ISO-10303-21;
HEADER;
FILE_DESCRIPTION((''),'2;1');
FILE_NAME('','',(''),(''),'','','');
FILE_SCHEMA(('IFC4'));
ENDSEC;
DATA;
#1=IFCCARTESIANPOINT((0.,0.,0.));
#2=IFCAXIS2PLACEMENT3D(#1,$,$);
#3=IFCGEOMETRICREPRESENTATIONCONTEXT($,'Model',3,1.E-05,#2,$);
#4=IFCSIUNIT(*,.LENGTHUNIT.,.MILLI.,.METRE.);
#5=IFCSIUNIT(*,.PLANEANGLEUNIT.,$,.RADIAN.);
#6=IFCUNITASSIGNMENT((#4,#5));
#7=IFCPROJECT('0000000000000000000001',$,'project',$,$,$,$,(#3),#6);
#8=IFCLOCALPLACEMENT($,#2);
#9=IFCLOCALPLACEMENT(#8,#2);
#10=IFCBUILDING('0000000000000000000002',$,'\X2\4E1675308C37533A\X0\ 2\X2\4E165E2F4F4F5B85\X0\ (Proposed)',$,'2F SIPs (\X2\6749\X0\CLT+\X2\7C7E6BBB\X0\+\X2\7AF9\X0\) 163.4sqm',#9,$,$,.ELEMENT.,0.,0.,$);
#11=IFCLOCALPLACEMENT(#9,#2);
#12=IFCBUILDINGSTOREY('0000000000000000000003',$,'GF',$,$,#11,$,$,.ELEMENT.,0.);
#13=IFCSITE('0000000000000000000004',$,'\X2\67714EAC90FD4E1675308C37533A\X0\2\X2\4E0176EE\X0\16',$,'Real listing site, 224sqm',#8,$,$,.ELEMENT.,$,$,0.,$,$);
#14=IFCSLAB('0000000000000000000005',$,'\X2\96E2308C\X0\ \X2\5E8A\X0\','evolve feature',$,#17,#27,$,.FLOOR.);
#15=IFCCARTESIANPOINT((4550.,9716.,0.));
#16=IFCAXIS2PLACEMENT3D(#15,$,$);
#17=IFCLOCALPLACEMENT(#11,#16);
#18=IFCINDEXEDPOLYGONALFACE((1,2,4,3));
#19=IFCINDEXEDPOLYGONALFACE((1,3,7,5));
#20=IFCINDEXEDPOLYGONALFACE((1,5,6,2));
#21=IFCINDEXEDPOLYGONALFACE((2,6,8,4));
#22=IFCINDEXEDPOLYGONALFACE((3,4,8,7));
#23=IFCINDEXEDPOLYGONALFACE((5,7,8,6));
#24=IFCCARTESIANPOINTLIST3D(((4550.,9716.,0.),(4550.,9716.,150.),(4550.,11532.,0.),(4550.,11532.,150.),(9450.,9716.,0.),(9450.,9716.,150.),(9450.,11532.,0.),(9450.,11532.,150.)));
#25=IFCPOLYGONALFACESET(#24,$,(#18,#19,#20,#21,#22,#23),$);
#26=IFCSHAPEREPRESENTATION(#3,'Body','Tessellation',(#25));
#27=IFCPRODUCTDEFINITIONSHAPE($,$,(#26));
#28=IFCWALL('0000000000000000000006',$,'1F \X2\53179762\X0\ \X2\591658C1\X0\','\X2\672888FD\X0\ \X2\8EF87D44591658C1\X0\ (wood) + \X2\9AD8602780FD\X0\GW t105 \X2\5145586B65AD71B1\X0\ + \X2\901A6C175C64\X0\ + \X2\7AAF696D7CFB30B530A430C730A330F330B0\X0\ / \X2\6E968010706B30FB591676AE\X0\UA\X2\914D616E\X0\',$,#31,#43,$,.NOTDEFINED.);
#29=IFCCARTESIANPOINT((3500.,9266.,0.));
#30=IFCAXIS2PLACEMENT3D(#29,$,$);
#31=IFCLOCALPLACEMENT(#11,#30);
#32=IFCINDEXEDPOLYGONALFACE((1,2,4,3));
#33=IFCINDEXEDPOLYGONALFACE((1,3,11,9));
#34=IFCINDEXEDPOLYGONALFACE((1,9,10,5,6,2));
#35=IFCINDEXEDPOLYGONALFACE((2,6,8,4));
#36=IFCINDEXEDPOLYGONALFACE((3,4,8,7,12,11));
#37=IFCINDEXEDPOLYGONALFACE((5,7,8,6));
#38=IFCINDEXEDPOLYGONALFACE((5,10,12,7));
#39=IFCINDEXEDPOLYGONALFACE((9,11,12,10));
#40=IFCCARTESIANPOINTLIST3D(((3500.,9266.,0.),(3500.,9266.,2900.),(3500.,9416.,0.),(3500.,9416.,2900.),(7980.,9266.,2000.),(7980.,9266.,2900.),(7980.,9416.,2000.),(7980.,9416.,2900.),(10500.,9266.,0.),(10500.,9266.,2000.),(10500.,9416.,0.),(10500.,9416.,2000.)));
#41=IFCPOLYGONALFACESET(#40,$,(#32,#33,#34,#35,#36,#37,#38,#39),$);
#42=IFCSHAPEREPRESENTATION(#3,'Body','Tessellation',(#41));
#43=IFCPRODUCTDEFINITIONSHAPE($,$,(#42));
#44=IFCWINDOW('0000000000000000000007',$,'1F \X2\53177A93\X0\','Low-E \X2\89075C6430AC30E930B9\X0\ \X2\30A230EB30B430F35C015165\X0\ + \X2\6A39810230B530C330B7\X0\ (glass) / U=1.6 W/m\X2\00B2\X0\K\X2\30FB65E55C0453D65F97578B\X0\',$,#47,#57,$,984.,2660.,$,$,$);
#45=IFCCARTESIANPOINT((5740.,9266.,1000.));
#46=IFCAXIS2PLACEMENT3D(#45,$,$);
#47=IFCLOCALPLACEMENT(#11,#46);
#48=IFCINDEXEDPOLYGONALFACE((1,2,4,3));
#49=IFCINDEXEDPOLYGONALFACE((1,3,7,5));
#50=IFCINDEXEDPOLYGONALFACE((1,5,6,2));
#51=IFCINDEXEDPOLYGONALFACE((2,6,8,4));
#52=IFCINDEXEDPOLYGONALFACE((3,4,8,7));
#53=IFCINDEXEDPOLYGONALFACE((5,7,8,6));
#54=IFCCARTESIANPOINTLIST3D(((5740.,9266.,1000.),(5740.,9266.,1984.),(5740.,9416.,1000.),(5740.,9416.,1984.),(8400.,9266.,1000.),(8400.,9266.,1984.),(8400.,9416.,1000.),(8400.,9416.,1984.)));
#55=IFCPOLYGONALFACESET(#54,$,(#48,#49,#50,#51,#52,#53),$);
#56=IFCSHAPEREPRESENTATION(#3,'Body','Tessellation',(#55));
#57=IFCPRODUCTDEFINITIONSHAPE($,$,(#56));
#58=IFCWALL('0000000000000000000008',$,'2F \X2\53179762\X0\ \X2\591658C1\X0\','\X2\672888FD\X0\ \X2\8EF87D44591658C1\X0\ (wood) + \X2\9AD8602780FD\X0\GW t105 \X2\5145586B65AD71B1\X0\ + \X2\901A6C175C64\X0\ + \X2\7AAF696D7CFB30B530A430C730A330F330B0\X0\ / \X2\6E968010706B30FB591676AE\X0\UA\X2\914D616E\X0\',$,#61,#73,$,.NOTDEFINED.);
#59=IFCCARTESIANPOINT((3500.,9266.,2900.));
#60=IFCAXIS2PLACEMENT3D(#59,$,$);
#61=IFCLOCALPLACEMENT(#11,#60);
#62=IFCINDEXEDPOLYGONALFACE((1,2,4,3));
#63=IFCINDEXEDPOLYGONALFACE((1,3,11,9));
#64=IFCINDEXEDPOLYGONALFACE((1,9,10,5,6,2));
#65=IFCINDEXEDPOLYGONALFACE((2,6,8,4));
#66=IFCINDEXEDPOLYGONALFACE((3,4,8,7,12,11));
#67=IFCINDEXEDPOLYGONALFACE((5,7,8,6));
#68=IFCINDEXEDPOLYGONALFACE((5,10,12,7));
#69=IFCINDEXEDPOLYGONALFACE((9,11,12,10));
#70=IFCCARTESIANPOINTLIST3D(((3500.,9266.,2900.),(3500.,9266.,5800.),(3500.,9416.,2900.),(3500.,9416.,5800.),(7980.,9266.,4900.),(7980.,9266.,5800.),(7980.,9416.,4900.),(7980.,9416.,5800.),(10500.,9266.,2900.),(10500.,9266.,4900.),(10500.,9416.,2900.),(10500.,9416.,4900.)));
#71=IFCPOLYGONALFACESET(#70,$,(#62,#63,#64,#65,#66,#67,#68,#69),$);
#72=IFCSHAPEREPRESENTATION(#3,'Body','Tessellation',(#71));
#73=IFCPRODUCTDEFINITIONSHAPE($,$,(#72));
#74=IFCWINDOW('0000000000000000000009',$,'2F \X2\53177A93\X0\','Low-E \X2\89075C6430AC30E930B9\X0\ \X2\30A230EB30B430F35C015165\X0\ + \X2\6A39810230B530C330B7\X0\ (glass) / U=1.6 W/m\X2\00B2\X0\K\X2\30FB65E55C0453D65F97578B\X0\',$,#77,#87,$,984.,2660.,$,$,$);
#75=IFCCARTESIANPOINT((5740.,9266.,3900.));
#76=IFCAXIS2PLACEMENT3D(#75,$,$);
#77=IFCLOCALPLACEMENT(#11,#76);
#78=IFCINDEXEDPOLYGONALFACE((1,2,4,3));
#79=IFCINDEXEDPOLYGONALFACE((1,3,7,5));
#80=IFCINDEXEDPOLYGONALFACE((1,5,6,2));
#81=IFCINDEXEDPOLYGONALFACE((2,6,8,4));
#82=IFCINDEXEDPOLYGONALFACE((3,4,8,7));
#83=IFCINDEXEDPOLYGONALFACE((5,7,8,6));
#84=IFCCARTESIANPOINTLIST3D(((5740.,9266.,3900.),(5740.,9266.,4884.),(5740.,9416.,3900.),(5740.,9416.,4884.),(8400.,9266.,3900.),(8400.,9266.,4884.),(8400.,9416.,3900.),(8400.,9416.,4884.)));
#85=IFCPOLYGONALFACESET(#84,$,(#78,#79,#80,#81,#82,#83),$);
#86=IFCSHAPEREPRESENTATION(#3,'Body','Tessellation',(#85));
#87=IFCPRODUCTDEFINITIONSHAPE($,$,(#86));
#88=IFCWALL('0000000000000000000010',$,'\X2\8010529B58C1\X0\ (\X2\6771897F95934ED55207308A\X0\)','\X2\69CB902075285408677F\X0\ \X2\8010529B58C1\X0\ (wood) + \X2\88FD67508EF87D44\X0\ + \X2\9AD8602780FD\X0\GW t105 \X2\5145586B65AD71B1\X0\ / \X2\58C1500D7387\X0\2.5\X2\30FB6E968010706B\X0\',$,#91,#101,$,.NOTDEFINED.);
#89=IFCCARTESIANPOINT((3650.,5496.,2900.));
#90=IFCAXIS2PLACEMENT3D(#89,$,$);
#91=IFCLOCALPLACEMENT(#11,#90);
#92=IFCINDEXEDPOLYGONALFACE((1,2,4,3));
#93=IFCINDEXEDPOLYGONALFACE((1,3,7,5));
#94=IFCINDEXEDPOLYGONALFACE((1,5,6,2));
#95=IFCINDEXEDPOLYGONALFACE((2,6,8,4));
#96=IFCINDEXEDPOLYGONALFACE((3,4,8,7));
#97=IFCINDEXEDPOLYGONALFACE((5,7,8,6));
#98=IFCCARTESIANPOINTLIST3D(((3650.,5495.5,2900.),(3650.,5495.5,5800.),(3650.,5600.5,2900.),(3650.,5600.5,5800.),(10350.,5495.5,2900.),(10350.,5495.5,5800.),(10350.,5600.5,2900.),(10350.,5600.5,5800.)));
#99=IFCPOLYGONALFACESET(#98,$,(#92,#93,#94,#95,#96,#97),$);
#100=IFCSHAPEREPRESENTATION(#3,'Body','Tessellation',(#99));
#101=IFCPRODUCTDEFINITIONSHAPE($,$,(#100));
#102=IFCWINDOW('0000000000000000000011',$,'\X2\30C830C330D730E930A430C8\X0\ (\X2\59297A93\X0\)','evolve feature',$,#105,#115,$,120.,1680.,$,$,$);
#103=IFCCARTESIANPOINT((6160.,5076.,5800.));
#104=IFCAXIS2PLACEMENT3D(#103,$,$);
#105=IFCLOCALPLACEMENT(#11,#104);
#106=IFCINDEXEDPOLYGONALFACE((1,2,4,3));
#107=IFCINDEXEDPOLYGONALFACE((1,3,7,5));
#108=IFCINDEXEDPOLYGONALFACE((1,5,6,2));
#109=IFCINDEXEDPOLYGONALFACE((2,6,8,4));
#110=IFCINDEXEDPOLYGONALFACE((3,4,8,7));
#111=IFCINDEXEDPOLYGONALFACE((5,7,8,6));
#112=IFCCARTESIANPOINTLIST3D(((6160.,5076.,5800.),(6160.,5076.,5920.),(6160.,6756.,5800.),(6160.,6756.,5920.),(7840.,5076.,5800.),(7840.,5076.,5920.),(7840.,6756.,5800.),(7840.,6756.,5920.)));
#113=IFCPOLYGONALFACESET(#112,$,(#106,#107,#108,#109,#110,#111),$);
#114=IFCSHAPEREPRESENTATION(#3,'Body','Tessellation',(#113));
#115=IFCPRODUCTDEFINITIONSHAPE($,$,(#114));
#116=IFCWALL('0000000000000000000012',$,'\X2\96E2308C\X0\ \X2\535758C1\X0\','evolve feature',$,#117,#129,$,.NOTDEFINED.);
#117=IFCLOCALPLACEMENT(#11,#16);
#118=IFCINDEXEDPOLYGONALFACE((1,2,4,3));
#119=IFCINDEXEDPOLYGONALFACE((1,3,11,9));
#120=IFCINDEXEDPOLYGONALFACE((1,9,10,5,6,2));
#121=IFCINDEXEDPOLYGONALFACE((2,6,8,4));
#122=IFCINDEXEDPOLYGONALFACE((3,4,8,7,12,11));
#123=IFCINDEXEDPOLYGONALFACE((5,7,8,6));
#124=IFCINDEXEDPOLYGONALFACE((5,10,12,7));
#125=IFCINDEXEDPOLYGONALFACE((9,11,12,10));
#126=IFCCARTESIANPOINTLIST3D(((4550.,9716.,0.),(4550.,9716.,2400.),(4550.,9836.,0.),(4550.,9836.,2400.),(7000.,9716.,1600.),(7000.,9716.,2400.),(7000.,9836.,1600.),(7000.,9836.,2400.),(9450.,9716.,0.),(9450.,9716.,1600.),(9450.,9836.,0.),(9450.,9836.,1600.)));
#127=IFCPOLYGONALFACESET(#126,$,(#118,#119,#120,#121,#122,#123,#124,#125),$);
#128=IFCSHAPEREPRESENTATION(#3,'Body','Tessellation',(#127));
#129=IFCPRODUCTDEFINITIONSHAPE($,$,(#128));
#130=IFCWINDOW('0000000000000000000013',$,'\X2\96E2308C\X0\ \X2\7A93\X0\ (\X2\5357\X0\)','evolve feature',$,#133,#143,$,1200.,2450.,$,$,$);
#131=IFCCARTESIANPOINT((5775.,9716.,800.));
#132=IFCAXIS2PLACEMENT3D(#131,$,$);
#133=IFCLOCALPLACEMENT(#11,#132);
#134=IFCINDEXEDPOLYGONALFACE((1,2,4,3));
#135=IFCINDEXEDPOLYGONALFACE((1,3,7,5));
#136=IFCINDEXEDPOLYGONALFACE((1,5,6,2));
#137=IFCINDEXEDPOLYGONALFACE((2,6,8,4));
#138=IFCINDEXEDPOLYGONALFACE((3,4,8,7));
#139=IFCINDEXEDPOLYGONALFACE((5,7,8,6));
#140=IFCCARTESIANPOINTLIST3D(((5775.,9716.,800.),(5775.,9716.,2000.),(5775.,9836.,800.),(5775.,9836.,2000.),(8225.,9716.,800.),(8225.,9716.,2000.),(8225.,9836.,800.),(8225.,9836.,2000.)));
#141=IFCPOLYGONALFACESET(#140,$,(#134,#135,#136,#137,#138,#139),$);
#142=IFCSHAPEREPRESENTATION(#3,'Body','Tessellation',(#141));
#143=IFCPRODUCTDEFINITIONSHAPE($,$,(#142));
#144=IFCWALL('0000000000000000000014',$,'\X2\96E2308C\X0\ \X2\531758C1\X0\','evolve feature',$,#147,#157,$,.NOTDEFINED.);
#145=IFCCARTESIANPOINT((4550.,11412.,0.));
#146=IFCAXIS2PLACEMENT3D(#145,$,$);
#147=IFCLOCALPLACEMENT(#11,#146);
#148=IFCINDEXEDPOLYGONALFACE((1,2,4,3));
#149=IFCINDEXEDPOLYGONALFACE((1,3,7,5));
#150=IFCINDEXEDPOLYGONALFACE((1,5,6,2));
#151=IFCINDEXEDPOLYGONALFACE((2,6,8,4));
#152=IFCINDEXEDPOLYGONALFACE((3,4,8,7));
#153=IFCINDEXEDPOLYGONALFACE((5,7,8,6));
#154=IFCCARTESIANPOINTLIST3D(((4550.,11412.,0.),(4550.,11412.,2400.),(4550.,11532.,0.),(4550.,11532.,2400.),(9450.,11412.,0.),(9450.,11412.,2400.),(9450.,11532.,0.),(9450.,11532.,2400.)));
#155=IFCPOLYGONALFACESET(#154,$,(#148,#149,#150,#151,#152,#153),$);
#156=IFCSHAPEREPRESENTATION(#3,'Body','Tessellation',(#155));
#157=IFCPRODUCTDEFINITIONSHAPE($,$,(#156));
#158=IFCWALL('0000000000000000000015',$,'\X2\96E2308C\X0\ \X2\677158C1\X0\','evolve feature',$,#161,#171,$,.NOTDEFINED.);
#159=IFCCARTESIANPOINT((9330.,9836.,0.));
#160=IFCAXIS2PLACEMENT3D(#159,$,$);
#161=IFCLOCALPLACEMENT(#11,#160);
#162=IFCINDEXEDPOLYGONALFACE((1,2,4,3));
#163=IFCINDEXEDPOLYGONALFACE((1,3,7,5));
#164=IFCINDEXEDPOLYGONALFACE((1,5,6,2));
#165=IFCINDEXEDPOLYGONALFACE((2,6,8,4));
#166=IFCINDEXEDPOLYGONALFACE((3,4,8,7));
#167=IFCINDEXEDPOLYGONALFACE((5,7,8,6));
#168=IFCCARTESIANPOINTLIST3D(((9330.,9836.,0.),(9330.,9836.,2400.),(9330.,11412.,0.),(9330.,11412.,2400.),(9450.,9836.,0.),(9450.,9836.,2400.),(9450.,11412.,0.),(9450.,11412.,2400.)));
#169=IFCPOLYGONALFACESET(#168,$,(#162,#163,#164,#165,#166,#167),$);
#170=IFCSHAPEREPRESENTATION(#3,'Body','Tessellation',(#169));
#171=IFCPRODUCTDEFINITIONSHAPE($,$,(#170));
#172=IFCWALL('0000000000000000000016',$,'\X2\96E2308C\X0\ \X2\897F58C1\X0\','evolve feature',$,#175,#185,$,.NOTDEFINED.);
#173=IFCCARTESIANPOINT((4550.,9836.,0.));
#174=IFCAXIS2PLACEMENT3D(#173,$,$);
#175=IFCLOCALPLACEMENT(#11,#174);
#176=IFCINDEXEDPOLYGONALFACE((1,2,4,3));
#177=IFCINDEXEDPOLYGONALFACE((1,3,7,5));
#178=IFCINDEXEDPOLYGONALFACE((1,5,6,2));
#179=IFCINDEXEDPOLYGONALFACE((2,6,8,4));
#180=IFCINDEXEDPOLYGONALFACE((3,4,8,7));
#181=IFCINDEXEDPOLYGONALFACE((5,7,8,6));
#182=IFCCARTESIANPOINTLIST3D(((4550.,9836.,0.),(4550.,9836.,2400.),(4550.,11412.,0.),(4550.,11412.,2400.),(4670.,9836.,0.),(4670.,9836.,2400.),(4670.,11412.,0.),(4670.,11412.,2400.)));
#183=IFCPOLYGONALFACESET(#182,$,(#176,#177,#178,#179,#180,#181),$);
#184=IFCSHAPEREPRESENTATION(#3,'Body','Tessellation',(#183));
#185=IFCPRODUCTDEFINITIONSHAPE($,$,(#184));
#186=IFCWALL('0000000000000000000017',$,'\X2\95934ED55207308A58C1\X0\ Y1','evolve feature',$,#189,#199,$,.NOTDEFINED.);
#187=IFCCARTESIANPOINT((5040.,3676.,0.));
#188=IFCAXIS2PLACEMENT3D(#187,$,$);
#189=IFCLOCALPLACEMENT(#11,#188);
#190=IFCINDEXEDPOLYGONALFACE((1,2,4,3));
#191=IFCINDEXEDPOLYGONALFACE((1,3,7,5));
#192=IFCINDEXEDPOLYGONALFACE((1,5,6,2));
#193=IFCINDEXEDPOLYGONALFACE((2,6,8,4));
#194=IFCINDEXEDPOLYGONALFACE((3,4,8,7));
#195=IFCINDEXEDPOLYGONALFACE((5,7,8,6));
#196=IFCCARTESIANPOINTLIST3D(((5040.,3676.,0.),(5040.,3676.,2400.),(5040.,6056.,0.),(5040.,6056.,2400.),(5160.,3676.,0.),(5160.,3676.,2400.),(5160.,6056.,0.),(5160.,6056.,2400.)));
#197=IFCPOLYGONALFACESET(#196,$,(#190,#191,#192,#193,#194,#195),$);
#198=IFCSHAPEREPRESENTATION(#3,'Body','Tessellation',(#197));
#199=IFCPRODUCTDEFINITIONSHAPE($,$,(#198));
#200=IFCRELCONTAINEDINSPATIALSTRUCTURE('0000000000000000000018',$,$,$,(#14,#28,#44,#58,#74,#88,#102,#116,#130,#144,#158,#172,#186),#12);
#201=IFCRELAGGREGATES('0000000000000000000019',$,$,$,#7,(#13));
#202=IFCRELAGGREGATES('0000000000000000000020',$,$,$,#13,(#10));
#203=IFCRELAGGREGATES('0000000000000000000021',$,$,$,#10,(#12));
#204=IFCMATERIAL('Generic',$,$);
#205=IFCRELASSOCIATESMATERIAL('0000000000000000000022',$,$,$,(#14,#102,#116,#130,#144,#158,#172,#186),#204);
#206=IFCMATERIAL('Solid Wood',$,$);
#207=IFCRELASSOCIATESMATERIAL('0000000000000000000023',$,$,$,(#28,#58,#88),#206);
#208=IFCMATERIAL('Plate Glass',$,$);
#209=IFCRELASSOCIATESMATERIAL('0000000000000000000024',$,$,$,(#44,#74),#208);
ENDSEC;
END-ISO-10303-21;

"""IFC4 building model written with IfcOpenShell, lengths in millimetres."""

from ifc_helpers import new_model, si_unit, frame, frame_2d, origin, place, context, project, spatial, rectangle, extrude, material, element, fill, save


model = new_model("IFC4")

# Units and contexts
model_context = context("Model", 3, precision=1e-05, world=origin())
ifc_project = project(units=[si_unit("LENGTHUNIT", "METRE", prefix="MILLI"), si_unit("PLANEANGLEUNIT", "RADIAN")], contexts=[model_context])

# Site, building, storey
site_placement = place(None, origin())
site = spatial("IfcSite", under=ifc_project, at=site_placement, Name="東京都世田谷区2丁目16", ObjectType="Real listing site, 224sqm", CompositionType="ELEMENT", RefElevation=0.0)
building_placement = place(site_placement, origin())
building = spatial("IfcBuilding", under=site, at=building_placement, Name="世田谷区 2世帯住宅 (Proposed)", ObjectType="2F SIPs (杉CLT+籾殻+竹) 163.4sqm", CompositionType="ELEMENT", ElevationOfRefHeight=0.0, ElevationOfTerrain=0.0)
storey_placement = place(building_placement, origin())
storey = spatial("IfcBuildingStorey", under=building, at=storey_placement, Name="GF", CompositionType="ELEMENT", Elevation=0.0)

# Slab
ifc_material_1 = material(Name="Generic")
slab_placement = place(storey_placement, frame((4550.0, 9716.0, 0.0)))
element("IfcSlab", 1, at=slab_placement, inside=storey, material=ifc_material_1, Name="離れ 床", Description="evolve feature", PredefinedType="FLOOR", context=model_context, shape_type="SweptSolid", body=[
    extrude(rectangle(XDim=4900.0, YDim=1816.0, at=frame_2d((2450.0, 908.0))), frame((4550.0, 9716.0, 0.0)), (0.0, 0.0, 1.0), 150.0),
])

# Wall, opening, window
ifc_material_2 = material(Name="Solid Wood")
wall_1_placement = place(storey_placement, frame((3500.0, 9266.0, 0.0)))
wall_1 = element("IfcWall", 2, at=wall_1_placement, inside=storey, material=ifc_material_2, Name="1F 北面 外壁", Description="木製 軸組外壁 (wood) + 高性能GW t105 充填断熱 + 通気層 + 窯業系サイディング / 準耐火・外皮UA配慮", PredefinedType="NOTDEFINED", context=model_context, shape_type="SweptSolid", body=[
    extrude(rectangle(XDim=7000.0, YDim=150.0, at=frame_2d((3500.0, 75.0))), frame((3500.0, 9266.0, 0.0)), (0.0, 0.0, 1.0), 2900.0),
])
opening_1_placement = place(storey_placement, frame((5740.0, 9266.0, 1000.0)))
opening_1 = element("IfcOpeningElement", 3, at=opening_1_placement, cuts=wall_1, PredefinedType="NOTDEFINED", context=model_context, shape_type="SweptSolid", body=[
    extrude(rectangle(XDim=2660.0, YDim=150.0, at=frame_2d((1330.0, 75.0))), frame((5740.0, 9266.0, 1000.0)), (0.0, 0.0, 1.0), 984.0),
])
ifc_material_3 = material(Name="Plate Glass")
window_1_placement = place(storey_placement, frame((5740.0, 9266.0, 1000.0)))
window_1 = element("IfcWindow", 4, at=window_1_placement, inside=storey, material=ifc_material_3, Name="1F 北窓", Description="Low-E 複層ガラス アルゴン封入 + 樹脂サッシ (glass) / U=1.6 W/m²K・日射取得型", OverallHeight=984.0, OverallWidth=2660.0, context=model_context, shape_type="SweptSolid", body=[
    extrude(rectangle(XDim=2660.0, YDim=150.0, at=frame_2d((1330.0, 75.0))), frame((5740.0, 9266.0, 1000.0)), (0.0, 0.0, 1.0), 984.0),
])
fill(opening_1, window_1)

# Wall, opening, window
wall_2_placement = place(storey_placement, frame((3500.0, 9266.0, 2900.0)))
wall_2 = element("IfcWall", 5, at=wall_2_placement, inside=storey, material=ifc_material_2, Name="2F 北面 外壁", Description="木製 軸組外壁 (wood) + 高性能GW t105 充填断熱 + 通気層 + 窯業系サイディング / 準耐火・外皮UA配慮", PredefinedType="NOTDEFINED", context=model_context, shape_type="SweptSolid", body=[
    extrude(rectangle(XDim=7000.0, YDim=150.0, at=frame_2d((3500.0, 75.0))), frame((3500.0, 9266.0, 2900.0)), (0.0, 0.0, 1.0), 2900.0),
])
opening_2_placement = place(storey_placement, frame((5740.0, 9266.0, 3900.0)))
opening_2 = element("IfcOpeningElement", 6, at=opening_2_placement, cuts=wall_2, PredefinedType="NOTDEFINED", context=model_context, shape_type="SweptSolid", body=[
    extrude(rectangle(XDim=2660.0, YDim=150.0, at=frame_2d((1330.0, 75.0))), frame((5740.0, 9266.0, 3900.0)), (0.0, 0.0, 1.0), 984.0),
])
window_2_placement = place(storey_placement, frame((5740.0, 9266.0, 3900.0)))
window_2 = element("IfcWindow", 7, at=window_2_placement, inside=storey, material=ifc_material_3, Name="2F 北窓", Description="Low-E 複層ガラス アルゴン封入 + 樹脂サッシ (glass) / U=1.6 W/m²K・日射取得型", OverallHeight=984.0, OverallWidth=2660.0, context=model_context, shape_type="SweptSolid", body=[
    extrude(rectangle(XDim=2660.0, YDim=150.0, at=frame_2d((1330.0, 75.0))), frame((5740.0, 9266.0, 3900.0)), (0.0, 0.0, 1.0), 984.0),
])
fill(opening_2, window_2)

# Wall
wall_3_placement = place(storey_placement, frame((3650.0, 5496.0, 2900.0)))
element("IfcWall", 8, at=wall_3_placement, inside=storey, material=ifc_material_2, Name="耐力壁 (東西間仕切り)", Description="構造用合板 耐力壁 (wood) + 製材軸組 + 高性能GW t105 充填断熱 / 壁倍率2.5・準耐火", PredefinedType="NOTDEFINED", context=model_context, shape_type="SweptSolid", body=[
    extrude(rectangle(XDim=6700.0, YDim=105.0, at=frame_2d((3350.0, 52.0))), frame((3650.0, 5496.0, 2900.0)), (0.0, 0.0, 1.0), 2900.0),
])

# Window
window_3_placement = place(storey_placement, frame((6160.0, 5076.0, 5800.0)))
element("IfcWindow", 9, at=window_3_placement, inside=storey, material=ifc_material_1, Name="トップライト (天窓)", Description="evolve feature", OverallHeight=120.0, OverallWidth=1680.0, context=model_context, shape_type="SweptSolid", body=[
    extrude(rectangle(XDim=1680.0, YDim=1680.0, at=frame_2d((840.0, 840.0))), frame((6160.0, 5076.0, 5800.0)), (0.0, 0.0, 1.0), 120.0),
])

# Wall, opening, window
wall_4_placement = place(storey_placement, frame((4550.0, 9716.0, 0.0)))
wall_4 = element("IfcWall", 10, at=wall_4_placement, inside=storey, material=ifc_material_1, Name="離れ 南壁", Description="evolve feature", PredefinedType="NOTDEFINED", context=model_context, shape_type="SweptSolid", body=[
    extrude(rectangle(XDim=4900.0, YDim=120.0, at=frame_2d((2450.0, 60.0))), frame((4550.0, 9716.0, 0.0)), (0.0, 0.0, 1.0), 2400.0),
])
opening_3_placement = place(storey_placement, frame((5775.0, 9716.0, 800.0)))
opening_3 = element("IfcOpeningElement", 11, at=opening_3_placement, cuts=wall_4, PredefinedType="NOTDEFINED", context=model_context, shape_type="SweptSolid", body=[
    extrude(rectangle(XDim=2450.0, YDim=120.0, at=frame_2d((1225.0, 60.0))), frame((5775.0, 9716.0, 800.0)), (0.0, 0.0, 1.0), 1200.0),
])
window_4_placement = place(storey_placement, frame((5775.0, 9716.0, 800.0)))
window_4 = element("IfcWindow", 12, at=window_4_placement, inside=storey, material=ifc_material_1, Name="離れ 窓 (南)", Description="evolve feature", OverallHeight=1200.0, OverallWidth=2450.0, context=model_context, shape_type="SweptSolid", body=[
    extrude(rectangle(XDim=2450.0, YDim=120.0, at=frame_2d((1225.0, 60.0))), frame((5775.0, 9716.0, 800.0)), (0.0, 0.0, 1.0), 1200.0),
])
fill(opening_3, window_4)

# Walls
wall_5_placement = place(storey_placement, frame((4550.0, 11412.0, 0.0)))
element("IfcWall", 13, at=wall_5_placement, inside=storey, material=ifc_material_1, Name="離れ 北壁", Description="evolve feature", PredefinedType="NOTDEFINED", context=model_context, shape_type="SweptSolid", body=[
    extrude(rectangle(XDim=4900.0, YDim=120.0, at=frame_2d((2450.0, 60.0))), frame((4550.0, 11412.0, 0.0)), (0.0, 0.0, 1.0), 2400.0),
])
wall_6_placement = place(storey_placement, frame((9330.0, 9836.0, 0.0)))
element("IfcWall", 14, at=wall_6_placement, inside=storey, material=ifc_material_1, Name="離れ 東壁", Description="evolve feature", PredefinedType="NOTDEFINED", context=model_context, shape_type="SweptSolid", body=[
    extrude(rectangle(XDim=120.0, YDim=1576.0, at=frame_2d((60.0, 788.0))), frame((9330.0, 9836.0, 0.0)), (0.0, 0.0, 1.0), 2400.0),
])
wall_7_placement = place(storey_placement, frame((4550.0, 9836.0, 0.0)))
element("IfcWall", 15, at=wall_7_placement, inside=storey, material=ifc_material_1, Name="離れ 西壁", Description="evolve feature", PredefinedType="NOTDEFINED", context=model_context, shape_type="SweptSolid", body=[
    extrude(rectangle(XDim=120.0, YDim=1576.0, at=frame_2d((60.0, 788.0))), frame((4550.0, 9836.0, 0.0)), (0.0, 0.0, 1.0), 2400.0),
])
wall_8_placement = place(storey_placement, frame((5040.0, 3676.0, 0.0)))
element("IfcWall", 16, at=wall_8_placement, inside=storey, material=ifc_material_1, Name="間仕切り壁 Y1", Description="evolve feature", PredefinedType="NOTDEFINED", context=model_context, shape_type="SweptSolid", body=[
    extrude(rectangle(XDim=120.0, YDim=2380.0, at=frame_2d((60.0, 1190.0))), frame((5040.0, 3676.0, 0.0)), (0.0, 0.0, 1.0), 2400.0),
])

save(model, "model.ifc")
